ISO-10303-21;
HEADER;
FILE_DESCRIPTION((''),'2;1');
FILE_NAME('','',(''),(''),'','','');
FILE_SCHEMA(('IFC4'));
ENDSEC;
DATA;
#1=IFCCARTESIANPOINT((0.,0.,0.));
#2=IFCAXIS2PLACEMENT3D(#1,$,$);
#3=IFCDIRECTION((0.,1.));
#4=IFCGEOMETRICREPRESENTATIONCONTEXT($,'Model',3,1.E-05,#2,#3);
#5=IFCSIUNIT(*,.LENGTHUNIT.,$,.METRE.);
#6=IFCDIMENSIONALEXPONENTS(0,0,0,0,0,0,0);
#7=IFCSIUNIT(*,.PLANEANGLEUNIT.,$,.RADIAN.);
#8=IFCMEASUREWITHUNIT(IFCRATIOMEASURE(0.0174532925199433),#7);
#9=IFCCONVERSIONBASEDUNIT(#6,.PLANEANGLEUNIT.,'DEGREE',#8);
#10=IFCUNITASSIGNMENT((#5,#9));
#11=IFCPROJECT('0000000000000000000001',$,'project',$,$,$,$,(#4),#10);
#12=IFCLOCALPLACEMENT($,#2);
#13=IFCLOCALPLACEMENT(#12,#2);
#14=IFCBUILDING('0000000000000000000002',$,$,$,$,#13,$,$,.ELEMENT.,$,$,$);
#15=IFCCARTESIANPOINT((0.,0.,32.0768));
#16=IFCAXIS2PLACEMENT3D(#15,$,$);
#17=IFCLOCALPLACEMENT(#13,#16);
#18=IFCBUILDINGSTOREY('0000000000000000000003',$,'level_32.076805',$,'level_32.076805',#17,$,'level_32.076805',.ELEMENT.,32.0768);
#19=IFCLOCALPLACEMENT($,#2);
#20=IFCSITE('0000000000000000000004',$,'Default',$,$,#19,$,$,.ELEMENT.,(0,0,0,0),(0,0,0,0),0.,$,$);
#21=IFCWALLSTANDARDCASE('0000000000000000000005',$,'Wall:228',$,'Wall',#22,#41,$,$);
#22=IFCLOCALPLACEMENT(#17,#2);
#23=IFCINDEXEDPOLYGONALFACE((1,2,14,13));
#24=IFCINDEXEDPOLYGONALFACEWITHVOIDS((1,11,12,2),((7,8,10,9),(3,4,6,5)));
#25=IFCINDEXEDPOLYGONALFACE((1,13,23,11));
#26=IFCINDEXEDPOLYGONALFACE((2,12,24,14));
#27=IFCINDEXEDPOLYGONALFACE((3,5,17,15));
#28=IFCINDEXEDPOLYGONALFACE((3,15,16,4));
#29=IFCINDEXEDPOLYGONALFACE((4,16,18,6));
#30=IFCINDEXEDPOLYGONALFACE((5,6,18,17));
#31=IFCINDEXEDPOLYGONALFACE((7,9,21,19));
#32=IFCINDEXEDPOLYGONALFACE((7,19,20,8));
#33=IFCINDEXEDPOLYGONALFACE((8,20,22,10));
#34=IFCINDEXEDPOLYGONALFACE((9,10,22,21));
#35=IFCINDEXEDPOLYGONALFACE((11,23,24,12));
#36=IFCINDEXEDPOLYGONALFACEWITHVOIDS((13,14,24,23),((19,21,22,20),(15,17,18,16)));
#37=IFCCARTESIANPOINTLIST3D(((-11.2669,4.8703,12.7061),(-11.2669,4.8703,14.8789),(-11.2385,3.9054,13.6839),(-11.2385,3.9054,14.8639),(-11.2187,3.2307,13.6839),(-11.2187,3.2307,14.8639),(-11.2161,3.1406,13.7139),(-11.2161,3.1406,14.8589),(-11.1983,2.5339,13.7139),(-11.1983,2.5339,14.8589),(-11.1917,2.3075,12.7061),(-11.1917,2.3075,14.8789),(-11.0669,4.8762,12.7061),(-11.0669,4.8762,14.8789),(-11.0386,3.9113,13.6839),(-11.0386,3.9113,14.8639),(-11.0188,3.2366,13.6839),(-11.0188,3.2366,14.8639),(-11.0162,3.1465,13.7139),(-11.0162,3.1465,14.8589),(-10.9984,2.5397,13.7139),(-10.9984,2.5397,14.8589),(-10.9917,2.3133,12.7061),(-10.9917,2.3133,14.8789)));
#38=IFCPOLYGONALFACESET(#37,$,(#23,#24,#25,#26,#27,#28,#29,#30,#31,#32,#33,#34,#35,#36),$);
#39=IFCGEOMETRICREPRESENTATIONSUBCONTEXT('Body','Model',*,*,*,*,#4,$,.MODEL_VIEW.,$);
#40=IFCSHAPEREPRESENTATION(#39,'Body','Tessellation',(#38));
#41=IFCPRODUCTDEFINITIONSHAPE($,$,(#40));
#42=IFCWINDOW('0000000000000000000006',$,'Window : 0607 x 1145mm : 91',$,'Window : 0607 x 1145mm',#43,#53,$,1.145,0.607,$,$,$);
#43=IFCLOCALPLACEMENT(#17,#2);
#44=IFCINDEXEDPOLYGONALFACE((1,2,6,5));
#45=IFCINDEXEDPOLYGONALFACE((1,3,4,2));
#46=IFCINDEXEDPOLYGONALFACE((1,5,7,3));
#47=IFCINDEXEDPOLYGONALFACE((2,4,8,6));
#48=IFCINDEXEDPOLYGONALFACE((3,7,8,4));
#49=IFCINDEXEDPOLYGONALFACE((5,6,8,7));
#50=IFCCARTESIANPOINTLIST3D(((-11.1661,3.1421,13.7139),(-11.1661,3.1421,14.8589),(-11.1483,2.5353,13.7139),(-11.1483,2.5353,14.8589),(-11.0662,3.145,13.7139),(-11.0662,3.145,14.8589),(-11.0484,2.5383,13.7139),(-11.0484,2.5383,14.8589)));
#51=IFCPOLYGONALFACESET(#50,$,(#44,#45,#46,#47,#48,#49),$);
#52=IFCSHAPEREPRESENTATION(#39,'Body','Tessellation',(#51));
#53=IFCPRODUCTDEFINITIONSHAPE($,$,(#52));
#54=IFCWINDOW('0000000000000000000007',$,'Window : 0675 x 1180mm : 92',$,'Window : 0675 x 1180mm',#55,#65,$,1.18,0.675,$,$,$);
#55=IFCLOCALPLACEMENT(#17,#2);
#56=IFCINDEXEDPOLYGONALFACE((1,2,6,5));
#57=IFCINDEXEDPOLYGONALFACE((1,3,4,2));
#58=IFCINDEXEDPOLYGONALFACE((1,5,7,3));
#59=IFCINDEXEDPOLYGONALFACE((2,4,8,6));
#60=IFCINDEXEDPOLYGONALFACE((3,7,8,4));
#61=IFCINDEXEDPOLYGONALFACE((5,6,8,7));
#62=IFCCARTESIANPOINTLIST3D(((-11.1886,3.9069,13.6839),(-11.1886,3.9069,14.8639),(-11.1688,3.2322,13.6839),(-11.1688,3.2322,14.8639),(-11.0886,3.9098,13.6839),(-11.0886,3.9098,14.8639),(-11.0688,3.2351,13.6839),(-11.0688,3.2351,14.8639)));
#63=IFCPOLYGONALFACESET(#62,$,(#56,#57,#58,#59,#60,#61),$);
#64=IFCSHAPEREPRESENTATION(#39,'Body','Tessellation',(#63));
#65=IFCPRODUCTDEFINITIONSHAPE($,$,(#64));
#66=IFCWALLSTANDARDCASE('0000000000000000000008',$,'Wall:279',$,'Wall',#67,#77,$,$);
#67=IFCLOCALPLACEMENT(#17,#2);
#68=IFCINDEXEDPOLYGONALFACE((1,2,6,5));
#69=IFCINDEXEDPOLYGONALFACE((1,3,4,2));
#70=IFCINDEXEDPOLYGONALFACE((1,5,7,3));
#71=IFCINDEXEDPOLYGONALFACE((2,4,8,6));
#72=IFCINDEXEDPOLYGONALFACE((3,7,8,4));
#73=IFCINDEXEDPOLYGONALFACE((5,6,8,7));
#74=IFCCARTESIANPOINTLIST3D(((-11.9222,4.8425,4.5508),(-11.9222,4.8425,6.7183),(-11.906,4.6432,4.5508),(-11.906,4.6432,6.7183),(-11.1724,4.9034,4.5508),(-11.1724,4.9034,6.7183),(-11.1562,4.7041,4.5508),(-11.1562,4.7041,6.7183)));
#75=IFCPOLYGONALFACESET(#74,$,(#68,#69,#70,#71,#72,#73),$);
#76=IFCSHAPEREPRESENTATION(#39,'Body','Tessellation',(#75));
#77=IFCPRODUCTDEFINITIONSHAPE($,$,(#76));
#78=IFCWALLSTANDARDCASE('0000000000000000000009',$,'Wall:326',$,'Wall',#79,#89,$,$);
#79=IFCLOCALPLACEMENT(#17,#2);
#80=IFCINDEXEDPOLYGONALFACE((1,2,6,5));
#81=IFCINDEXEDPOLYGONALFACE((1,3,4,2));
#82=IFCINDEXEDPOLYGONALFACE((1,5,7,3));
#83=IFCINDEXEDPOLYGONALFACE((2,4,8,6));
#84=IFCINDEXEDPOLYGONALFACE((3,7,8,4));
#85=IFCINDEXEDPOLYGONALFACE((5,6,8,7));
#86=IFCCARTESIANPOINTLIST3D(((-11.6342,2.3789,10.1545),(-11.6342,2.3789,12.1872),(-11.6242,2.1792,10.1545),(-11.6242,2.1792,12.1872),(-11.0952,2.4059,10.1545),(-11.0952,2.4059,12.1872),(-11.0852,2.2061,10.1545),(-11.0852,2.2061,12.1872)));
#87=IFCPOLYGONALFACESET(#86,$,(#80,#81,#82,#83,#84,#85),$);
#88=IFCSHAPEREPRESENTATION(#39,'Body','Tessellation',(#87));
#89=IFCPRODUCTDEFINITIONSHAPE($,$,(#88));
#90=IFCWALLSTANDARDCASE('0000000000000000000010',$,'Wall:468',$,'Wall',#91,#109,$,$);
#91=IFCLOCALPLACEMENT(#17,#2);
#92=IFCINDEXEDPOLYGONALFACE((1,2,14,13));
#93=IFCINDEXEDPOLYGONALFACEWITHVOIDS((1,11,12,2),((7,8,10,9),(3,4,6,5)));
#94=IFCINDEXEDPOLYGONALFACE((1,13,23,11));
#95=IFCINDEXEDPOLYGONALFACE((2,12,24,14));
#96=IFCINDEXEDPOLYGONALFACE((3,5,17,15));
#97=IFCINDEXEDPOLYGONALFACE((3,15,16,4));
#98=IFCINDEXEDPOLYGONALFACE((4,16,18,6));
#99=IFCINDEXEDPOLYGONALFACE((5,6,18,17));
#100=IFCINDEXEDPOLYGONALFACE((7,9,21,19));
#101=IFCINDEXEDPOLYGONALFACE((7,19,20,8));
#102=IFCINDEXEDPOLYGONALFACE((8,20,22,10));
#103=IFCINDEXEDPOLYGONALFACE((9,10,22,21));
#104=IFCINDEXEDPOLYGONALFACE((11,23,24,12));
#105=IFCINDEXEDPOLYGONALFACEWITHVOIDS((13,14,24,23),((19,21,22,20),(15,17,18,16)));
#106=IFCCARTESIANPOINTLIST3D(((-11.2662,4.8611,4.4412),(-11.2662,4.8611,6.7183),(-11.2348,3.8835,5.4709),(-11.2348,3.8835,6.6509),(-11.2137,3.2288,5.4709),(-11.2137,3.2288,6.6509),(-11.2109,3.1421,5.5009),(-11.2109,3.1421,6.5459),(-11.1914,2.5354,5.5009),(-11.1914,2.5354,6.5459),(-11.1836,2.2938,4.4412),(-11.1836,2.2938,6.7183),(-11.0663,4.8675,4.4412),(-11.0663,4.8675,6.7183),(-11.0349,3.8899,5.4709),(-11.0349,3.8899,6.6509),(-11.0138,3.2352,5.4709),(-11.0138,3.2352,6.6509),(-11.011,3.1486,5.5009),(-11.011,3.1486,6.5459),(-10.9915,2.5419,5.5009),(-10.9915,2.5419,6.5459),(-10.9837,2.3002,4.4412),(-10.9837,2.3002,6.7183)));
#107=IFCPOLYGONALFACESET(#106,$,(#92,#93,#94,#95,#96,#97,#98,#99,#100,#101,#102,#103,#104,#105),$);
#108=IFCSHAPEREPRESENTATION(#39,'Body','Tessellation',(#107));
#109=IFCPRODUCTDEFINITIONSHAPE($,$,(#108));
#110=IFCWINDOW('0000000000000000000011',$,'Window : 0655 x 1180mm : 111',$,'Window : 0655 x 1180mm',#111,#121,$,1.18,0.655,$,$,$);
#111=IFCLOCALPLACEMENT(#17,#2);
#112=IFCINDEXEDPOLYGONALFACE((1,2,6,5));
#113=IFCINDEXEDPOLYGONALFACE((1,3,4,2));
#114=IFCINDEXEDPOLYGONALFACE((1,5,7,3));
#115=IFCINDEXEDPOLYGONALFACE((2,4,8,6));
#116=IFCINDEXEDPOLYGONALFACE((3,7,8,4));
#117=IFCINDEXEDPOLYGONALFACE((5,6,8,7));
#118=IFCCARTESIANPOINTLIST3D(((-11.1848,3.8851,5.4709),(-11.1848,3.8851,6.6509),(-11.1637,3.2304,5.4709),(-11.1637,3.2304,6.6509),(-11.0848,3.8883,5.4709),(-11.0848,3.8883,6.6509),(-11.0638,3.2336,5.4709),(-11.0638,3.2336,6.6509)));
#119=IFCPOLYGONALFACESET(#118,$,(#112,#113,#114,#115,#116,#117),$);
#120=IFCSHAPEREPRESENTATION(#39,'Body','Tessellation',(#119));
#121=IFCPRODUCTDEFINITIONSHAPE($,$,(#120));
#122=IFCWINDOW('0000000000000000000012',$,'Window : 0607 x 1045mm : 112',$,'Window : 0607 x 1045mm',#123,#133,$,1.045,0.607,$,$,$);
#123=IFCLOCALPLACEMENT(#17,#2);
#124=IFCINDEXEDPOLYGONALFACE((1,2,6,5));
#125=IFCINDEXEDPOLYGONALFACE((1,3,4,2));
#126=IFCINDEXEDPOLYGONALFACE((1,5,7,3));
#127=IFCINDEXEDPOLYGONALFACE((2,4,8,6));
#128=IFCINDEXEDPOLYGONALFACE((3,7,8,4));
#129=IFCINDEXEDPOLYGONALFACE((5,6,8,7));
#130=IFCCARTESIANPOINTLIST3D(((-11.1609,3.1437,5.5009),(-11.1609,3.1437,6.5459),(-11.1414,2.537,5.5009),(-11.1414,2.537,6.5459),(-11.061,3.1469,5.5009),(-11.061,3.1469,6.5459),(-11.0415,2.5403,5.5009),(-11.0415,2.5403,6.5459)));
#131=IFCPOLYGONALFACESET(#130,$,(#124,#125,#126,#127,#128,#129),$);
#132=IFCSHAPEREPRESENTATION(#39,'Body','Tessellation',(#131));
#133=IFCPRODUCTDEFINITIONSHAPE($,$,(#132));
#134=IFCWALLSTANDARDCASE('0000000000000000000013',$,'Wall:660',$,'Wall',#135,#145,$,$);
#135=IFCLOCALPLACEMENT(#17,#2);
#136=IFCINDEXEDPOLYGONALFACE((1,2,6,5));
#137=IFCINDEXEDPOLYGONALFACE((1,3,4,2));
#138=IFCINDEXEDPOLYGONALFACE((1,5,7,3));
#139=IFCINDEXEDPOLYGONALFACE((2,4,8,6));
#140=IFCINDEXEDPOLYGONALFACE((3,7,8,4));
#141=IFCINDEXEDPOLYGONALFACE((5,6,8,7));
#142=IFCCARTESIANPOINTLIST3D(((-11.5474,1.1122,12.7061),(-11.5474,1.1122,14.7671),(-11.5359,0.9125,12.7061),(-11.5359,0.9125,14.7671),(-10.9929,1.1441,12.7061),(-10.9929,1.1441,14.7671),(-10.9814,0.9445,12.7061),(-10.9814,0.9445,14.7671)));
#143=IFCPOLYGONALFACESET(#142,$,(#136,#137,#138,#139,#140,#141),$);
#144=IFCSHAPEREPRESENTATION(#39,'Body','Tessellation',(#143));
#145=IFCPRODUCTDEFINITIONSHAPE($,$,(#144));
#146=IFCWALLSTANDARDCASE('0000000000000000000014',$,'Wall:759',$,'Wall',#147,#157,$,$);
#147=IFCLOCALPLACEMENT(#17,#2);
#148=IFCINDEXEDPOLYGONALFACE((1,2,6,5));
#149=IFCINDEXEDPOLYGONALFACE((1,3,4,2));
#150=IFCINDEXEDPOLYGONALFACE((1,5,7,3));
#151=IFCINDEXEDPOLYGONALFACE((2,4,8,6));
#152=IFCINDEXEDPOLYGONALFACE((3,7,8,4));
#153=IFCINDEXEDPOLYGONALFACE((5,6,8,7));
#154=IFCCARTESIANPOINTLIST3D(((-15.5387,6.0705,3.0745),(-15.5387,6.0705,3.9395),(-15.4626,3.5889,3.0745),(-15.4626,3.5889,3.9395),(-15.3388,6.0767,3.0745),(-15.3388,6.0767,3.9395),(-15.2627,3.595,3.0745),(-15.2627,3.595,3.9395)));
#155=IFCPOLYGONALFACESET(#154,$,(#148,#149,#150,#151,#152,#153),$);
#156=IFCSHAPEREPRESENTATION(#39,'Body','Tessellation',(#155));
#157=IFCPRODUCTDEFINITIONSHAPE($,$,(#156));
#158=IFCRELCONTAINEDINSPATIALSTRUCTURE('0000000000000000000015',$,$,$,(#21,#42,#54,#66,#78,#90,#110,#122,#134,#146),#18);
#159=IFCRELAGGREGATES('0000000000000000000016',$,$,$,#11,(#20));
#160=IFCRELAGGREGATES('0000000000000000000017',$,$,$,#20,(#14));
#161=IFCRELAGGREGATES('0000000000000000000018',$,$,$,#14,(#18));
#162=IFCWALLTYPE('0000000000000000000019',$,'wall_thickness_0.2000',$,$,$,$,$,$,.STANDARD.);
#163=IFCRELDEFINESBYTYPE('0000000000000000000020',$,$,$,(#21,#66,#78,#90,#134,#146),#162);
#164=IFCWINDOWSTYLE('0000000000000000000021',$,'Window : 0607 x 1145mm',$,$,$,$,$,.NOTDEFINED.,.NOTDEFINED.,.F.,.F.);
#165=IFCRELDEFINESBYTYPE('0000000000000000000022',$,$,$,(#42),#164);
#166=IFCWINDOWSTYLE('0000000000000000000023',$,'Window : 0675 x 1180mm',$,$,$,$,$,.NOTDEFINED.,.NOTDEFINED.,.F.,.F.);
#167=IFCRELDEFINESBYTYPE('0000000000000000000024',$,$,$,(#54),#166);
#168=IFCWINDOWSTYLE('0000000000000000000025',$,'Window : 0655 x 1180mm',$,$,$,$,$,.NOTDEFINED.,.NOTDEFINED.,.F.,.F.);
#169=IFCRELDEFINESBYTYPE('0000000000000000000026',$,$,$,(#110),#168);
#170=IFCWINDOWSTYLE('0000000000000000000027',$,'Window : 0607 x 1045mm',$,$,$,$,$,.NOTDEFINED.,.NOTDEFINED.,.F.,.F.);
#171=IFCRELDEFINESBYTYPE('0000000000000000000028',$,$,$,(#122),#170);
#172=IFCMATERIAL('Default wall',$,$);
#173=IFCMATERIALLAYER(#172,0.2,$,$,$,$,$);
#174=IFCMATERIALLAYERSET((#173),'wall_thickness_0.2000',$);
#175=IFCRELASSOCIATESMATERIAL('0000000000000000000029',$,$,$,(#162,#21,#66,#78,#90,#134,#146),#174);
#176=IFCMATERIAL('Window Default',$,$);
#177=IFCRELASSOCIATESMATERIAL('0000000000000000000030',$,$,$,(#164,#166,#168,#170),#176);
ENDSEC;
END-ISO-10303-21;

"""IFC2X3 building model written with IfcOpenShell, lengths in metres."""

from ifc_helpers import new_model, entity, si_unit, converted_unit, direction, frame, frame_2d, origin, origin_2d_with_axis, place, context, subcontext, project, spatial, polyline, rectangle, outline, extrude, source, transform, mapped, material, layer, layer_set, layer_usage, type_object, type_shapes, element, fill, save


model = new_model("IFC2X3")

# Units and contexts
model_context = context("Model", 3, precision=1e-05, world=origin(), true_north=direction((0.0, 1.0)))
body_context = subcontext(model_context, "Body", "Model", "MODEL_VIEW")
ifc_project = project(units=[si_unit("LENGTHUNIT", "METRE"), converted_unit("PLANEANGLEUNIT", "DEGREE", entity("IfcRatioMeasure", 0.0174532925199433), si_unit("PLANEANGLEUNIT", "RADIAN"), dimensions=[0, 0, 0, 0, 0, 0, 0])], contexts=[model_context])

# Site, building, storey
site_placement = place(None, origin())
site = spatial("IfcSite", under=ifc_project, at=site_placement, Name="Default", CompositionType="ELEMENT", RefLatitude=(0, 0, 0, 0), RefLongitude=(0, 0, 0, 0), RefElevation=0.0)
placement_1 = place(None, origin())
building_placement = place(placement_1, origin())
building = spatial("IfcBuilding", under=site, at=building_placement, CompositionType="ELEMENT")
storey_placement = place(building_placement, frame((0.0, 0.0, 32.0768)))
storey = spatial("IfcBuildingStorey", under=building, at=storey_placement, Name="level_32.076805", ObjectType="level_32.076805", LongName="level_32.076805", CompositionType="ELEMENT", Elevation=32.0768)

# Wall, openings, windows
ifc_material_1 = material(Name="Default wall")
ifc_layer = layer(ifc_material_1, 0.2)
ifc_layer_set = layer_set([ifc_layer], Name="wall_thickness_0.2000")
ifc_layer_usage = layer_usage(ifc_layer_set, "AXIS2", "POSITIVE", -0.1)
wall_type = type_object("IfcWallType", Name="wall_thickness_0.2000", PredefinedType="STANDARD", material=ifc_layer_set)
placement_2 = place(building_placement, frame((0.0, 0.0, 44.7829)))
wall_1_placement = place(placement_2, frame((-11.0917, 2.3104, 0.0), z_axis=(0.0, 0.0, 1.0), x_axis=(-0.029331, 0.99957, 0.0)))
wall_1 = element("IfcWallStandardCase", 1, at=wall_1_placement, inside=storey, type_object=wall_type, material=ifc_layer_usage, Name="Wall:228", ObjectType="Wall", context=body_context, shape_type="SweptSolid", body=[
    extrude(outline(polyline([(2.5639, -0.1), (2.5639, 0.1), (0.0, 0.1), (0.0, -0.1), (2.5639, -0.1)])), origin(), (0.0, 0.0, 1.0), 2.1729),
])
opening_1_placement = place(wall_1_placement, frame((0.2265, -0.1, 1.0079)))
opening_1 = element("IfcOpeningElement", 2, at=opening_1_placement, cuts=wall_1, ObjectType="Opening", context=body_context, shape_type="SweptSolid", body=[
    extrude(rectangle(XDim=0.607, YDim=1.145, at=frame_2d((0.5725, 0.3035), x_axis=(0.0, 1.0))), frame((0.0, 0.0, 0.0), z_axis=(0.0, 1.0, 0.0), x_axis=(0.0, 0.0, 1.0)), (0.0, 0.0, 1.0), 0.2),
])
opening_2_placement = place(wall_1_placement, frame((0.9237, -0.1, 0.9779)))
opening_2 = element("IfcOpeningElement", 3, at=opening_2_placement, cuts=wall_1, ObjectType="Opening", context=body_context, shape_type="SweptSolid", body=[
    extrude(rectangle(XDim=0.675, YDim=1.18, at=frame_2d((0.59, 0.3375), x_axis=(0.0, 1.0))), frame((0.0, 0.0, 0.0), z_axis=(0.0, 1.0, 0.0), x_axis=(0.0, 0.0, 1.0)), (0.0, 0.0, 1.0), 0.2),
])
ifc_material_2 = material(Name="Window Default")
window_style_1 = type_object("IfcWindowStyle", Name="Window : 0607 x 1145mm", ConstructionType="NOTDEFINED", OperationType="NOTDEFINED", ParameterTakesPrecedence=False, Sizeable=False, material=ifc_material_2)
shared_shape_1 = source(origin(), body_context, "Body", "SweptSolid", [
    extrude(rectangle(XDim=0.1, YDim=0.607, at=origin_2d_with_axis()), frame((0.3035, 0.1, 0.0), z_axis=(0.0, 0.0, 1.0), x_axis=(0.0, 1.0, 0.0)), (0.0, 0.0, 1.0), 1.145),
])
type_shapes(window_style_1, [shared_shape_1])
window_1_placement = place(opening_1_placement, origin())
window_1 = element("IfcWindow", 4, at=window_1_placement, inside=storey, type_object=window_style_1, Name="Window : 0607 x 1145mm : 91", ObjectType="Window : 0607 x 1145mm", OverallHeight=1.145, OverallWidth=0.607, context=body_context, shape_type="MappedRepresentation", body=[
    mapped(shared_shape_1, transform((0.0, 0.0, 0.0), scale=1.0)),
])
fill(opening_1, window_1)
window_style_2 = type_object("IfcWindowStyle", Name="Window : 0675 x 1180mm", ConstructionType="NOTDEFINED", OperationType="NOTDEFINED", ParameterTakesPrecedence=False, Sizeable=False, material=ifc_material_2)
shared_shape_2 = source(origin(), body_context, "Body", "SweptSolid", [
    extrude(rectangle(XDim=0.1, YDim=0.675, at=origin_2d_with_axis()), frame((0.3375, 0.1, 0.0), z_axis=(0.0, 0.0, 1.0), x_axis=(0.0, 1.0, 0.0)), (0.0, 0.0, 1.0), 1.18),
])
type_shapes(window_style_2, [shared_shape_2])
window_2_placement = place(opening_2_placement, origin())
window_2 = element("IfcWindow", 5, at=window_2_placement, inside=storey, type_object=window_style_2, Name="Window : 0675 x 1180mm : 92", ObjectType="Window : 0675 x 1180mm", OverallHeight=1.18, OverallWidth=0.675, context=body_context, shape_type="MappedRepresentation", body=[
    mapped(shared_shape_2, transform((0.0, 0.0, 0.0), scale=1.0)),
])
fill(opening_2, window_2)

# Walls
placement_3 = place(building_placement, frame((0.0, 0.0, 36.6276)))
wall_2_placement = place(placement_3, frame((-11.1643, 4.8037, 0.0), z_axis=(0.0, 0.0, 1.0), x_axis=(-0.99672, -0.080929, 0.0)))
element("IfcWallStandardCase", 6, at=wall_2_placement, inside=storey, type_object=wall_type, material=ifc_layer_usage, Name="Wall:279", ObjectType="Wall", context=body_context, shape_type="SweptSolid", body=[
    extrude(outline(polyline([(0.7523, -0.1), (0.7523, 0.1), (0.0, 0.1), (0.0, -0.1), (0.7523, -0.1)])), origin(), (0.0, 0.0, 1.0), 2.1675),
])
placement_4 = place(building_placement, frame((0.0, 0.0, 42.2313)))
wall_3_placement = place(placement_4, frame((-11.0902, 2.306, 0.0), z_axis=(0.0, 0.0, 1.0), x_axis=(-0.99875, -0.049982, 0.0)))
element("IfcWallStandardCase", 7, at=wall_3_placement, inside=storey, type_object=wall_type, material=ifc_layer_usage, Name="Wall:326", ObjectType="Wall", context=body_context, shape_type="SweptSolid", body=[
    extrude(outline(polyline([(0.5397, -0.1), (0.5397, 0.1), (0.0, 0.1), (0.0, -0.1), (0.5397, -0.1)])), origin(), (0.0, 0.0, 1.0), 2.0328),
])

# Wall, openings, windows
placement_5 = place(building_placement, frame((0.0, 0.0, 36.518)))
wall_4_placement = place(placement_5, frame((-11.0837, 2.297, 0.0), z_axis=(0.0, 0.0, 1.0), x_axis=(-0.032141, 0.999483, 0.0)))
wall_4 = element("IfcWallStandardCase", 8, at=wall_4_placement, inside=storey, type_object=wall_type, material=ifc_layer_usage, Name="Wall:468", ObjectType="Wall", context=body_context, shape_type="SweptSolid", body=[
    extrude(outline(polyline([(2.5686, -0.1), (2.5686, 0.1), (0.0, 0.1), (0.0, -0.1), (2.5686, -0.1)])), origin(), (0.0, 0.0, 1.0), 2.2771),
])
opening_3_placement = place(wall_4_placement, frame((0.9355, -0.1, 1.0297)))
opening_3 = element("IfcOpeningElement", 9, at=opening_3_placement, cuts=wall_4, ObjectType="Opening", context=body_context, shape_type="SweptSolid", body=[
    extrude(rectangle(XDim=0.655, YDim=1.18, at=frame_2d((0.59, 0.3275), x_axis=(0.0, 1.0))), frame((0.0, 0.0, 0.0), z_axis=(0.0, 1.0, 0.0), x_axis=(0.0, 0.0, 1.0)), (0.0, 0.0, 1.0), 0.2),
])
opening_4_placement = place(wall_4_placement, frame((0.2418, -0.1, 1.0597)))
opening_4 = element("IfcOpeningElement", 10, at=opening_4_placement, cuts=wall_4, ObjectType="Opening", context=body_context, shape_type="SweptSolid", body=[
    extrude(rectangle(XDim=0.607, YDim=1.045, at=frame_2d((0.5225, 0.3035), x_axis=(0.0, 1.0))), frame((0.0, 0.0, 0.0), z_axis=(0.0, 1.0, 0.0), x_axis=(0.0, 0.0, 1.0)), (0.0, 0.0, 1.0), 0.2),
])
window_style_3 = type_object("IfcWindowStyle", Name="Window : 0655 x 1180mm", ConstructionType="NOTDEFINED", OperationType="NOTDEFINED", ParameterTakesPrecedence=False, Sizeable=False, material=ifc_material_2)
shared_shape_3 = source(origin(), body_context, "Body", "SweptSolid", [
    extrude(rectangle(XDim=0.1, YDim=0.655, at=origin_2d_with_axis()), frame((0.3275, 0.1, 0.0), z_axis=(0.0, 0.0, 1.0), x_axis=(0.0, 1.0, 0.0)), (0.0, 0.0, 1.0), 1.18),
])
type_shapes(window_style_3, [shared_shape_3])
window_3_placement = place(opening_3_placement, origin())
window_3 = element("IfcWindow", 11, at=window_3_placement, inside=storey, type_object=window_style_3, Name="Window : 0655 x 1180mm : 111", ObjectType="Window : 0655 x 1180mm", OverallHeight=1.18, OverallWidth=0.655, context=body_context, shape_type="MappedRepresentation", body=[
    mapped(shared_shape_3, transform((0.0, 0.0, 0.0), scale=1.0)),
])
fill(opening_3, window_3)
window_style_4 = type_object("IfcWindowStyle", Name="Window : 0607 x 1045mm", ConstructionType="NOTDEFINED", OperationType="NOTDEFINED", ParameterTakesPrecedence=False, Sizeable=False, material=ifc_material_2)
shared_shape_4 = source(origin(), body_context, "Body", "SweptSolid", [
    extrude(rectangle(XDim=0.1, YDim=0.607, at=origin_2d_with_axis()), frame((0.3035, 0.1, 0.0), z_axis=(0.0, 0.0, 1.0), x_axis=(0.0, 1.0, 0.0)), (0.0, 0.0, 1.0), 1.045),
])
type_shapes(window_style_4, [shared_shape_4])
window_4_placement = place(opening_4_placement, origin())
window_4 = element("IfcWindow", 12, at=window_4_placement, inside=storey, type_object=window_style_4, Name="Window : 0607 x 1045mm : 112", ObjectType="Window : 0607 x 1045mm", OverallHeight=1.045, OverallWidth=0.607, context=body_context, shape_type="MappedRepresentation", body=[
    mapped(shared_shape_4, transform((0.0, 0.0, 0.0), scale=1.0)),
])
fill(opening_4, window_4)

# Walls
placement_6 = place(building_placement, frame((0.0, 0.0, 44.7829)))
wall_5_placement = place(placement_6, frame((-10.9872, 1.0443, 0.0), z_axis=(0.0, 0.0, 1.0), x_axis=(-0.998345, -0.057511, 0.0)))
element("IfcWallStandardCase", 13, at=wall_5_placement, inside=storey, type_object=wall_type, material=ifc_layer_usage, Name="Wall:660", ObjectType="Wall", context=body_context, shape_type="SweptSolid", body=[
    extrude(outline(polyline([(0.5554, -0.1), (0.5554, 0.1), (0.0, 0.1), (0.0, -0.1), (0.5554, -0.1)])), origin(), (0.0, 0.0, 1.0), 2.061),
])
placement_7 = place(building_placement, frame((0.0, 0.0, 35.1513)))
wall_6_placement = place(placement_7, frame((-15.3626, 3.5919, 0.0), z_axis=(0.0, 0.0, 1.0), x_axis=(-0.030656, 0.99953, 0.0)))
element("IfcWallStandardCase", 14, at=wall_6_placement, inside=storey, type_object=wall_type, material=ifc_layer_usage, Name="Wall:759", ObjectType="Wall", context=body_context, shape_type="SweptSolid", body=[
    extrude(outline(polyline([(2.4828, -0.1), (2.4828, 0.1), (0.0, 0.1), (0.0, -0.1), (2.4828, -0.1)])), origin(), (0.0, 0.0, 1.0), 0.865),
])

save(model, "model.ifc")
